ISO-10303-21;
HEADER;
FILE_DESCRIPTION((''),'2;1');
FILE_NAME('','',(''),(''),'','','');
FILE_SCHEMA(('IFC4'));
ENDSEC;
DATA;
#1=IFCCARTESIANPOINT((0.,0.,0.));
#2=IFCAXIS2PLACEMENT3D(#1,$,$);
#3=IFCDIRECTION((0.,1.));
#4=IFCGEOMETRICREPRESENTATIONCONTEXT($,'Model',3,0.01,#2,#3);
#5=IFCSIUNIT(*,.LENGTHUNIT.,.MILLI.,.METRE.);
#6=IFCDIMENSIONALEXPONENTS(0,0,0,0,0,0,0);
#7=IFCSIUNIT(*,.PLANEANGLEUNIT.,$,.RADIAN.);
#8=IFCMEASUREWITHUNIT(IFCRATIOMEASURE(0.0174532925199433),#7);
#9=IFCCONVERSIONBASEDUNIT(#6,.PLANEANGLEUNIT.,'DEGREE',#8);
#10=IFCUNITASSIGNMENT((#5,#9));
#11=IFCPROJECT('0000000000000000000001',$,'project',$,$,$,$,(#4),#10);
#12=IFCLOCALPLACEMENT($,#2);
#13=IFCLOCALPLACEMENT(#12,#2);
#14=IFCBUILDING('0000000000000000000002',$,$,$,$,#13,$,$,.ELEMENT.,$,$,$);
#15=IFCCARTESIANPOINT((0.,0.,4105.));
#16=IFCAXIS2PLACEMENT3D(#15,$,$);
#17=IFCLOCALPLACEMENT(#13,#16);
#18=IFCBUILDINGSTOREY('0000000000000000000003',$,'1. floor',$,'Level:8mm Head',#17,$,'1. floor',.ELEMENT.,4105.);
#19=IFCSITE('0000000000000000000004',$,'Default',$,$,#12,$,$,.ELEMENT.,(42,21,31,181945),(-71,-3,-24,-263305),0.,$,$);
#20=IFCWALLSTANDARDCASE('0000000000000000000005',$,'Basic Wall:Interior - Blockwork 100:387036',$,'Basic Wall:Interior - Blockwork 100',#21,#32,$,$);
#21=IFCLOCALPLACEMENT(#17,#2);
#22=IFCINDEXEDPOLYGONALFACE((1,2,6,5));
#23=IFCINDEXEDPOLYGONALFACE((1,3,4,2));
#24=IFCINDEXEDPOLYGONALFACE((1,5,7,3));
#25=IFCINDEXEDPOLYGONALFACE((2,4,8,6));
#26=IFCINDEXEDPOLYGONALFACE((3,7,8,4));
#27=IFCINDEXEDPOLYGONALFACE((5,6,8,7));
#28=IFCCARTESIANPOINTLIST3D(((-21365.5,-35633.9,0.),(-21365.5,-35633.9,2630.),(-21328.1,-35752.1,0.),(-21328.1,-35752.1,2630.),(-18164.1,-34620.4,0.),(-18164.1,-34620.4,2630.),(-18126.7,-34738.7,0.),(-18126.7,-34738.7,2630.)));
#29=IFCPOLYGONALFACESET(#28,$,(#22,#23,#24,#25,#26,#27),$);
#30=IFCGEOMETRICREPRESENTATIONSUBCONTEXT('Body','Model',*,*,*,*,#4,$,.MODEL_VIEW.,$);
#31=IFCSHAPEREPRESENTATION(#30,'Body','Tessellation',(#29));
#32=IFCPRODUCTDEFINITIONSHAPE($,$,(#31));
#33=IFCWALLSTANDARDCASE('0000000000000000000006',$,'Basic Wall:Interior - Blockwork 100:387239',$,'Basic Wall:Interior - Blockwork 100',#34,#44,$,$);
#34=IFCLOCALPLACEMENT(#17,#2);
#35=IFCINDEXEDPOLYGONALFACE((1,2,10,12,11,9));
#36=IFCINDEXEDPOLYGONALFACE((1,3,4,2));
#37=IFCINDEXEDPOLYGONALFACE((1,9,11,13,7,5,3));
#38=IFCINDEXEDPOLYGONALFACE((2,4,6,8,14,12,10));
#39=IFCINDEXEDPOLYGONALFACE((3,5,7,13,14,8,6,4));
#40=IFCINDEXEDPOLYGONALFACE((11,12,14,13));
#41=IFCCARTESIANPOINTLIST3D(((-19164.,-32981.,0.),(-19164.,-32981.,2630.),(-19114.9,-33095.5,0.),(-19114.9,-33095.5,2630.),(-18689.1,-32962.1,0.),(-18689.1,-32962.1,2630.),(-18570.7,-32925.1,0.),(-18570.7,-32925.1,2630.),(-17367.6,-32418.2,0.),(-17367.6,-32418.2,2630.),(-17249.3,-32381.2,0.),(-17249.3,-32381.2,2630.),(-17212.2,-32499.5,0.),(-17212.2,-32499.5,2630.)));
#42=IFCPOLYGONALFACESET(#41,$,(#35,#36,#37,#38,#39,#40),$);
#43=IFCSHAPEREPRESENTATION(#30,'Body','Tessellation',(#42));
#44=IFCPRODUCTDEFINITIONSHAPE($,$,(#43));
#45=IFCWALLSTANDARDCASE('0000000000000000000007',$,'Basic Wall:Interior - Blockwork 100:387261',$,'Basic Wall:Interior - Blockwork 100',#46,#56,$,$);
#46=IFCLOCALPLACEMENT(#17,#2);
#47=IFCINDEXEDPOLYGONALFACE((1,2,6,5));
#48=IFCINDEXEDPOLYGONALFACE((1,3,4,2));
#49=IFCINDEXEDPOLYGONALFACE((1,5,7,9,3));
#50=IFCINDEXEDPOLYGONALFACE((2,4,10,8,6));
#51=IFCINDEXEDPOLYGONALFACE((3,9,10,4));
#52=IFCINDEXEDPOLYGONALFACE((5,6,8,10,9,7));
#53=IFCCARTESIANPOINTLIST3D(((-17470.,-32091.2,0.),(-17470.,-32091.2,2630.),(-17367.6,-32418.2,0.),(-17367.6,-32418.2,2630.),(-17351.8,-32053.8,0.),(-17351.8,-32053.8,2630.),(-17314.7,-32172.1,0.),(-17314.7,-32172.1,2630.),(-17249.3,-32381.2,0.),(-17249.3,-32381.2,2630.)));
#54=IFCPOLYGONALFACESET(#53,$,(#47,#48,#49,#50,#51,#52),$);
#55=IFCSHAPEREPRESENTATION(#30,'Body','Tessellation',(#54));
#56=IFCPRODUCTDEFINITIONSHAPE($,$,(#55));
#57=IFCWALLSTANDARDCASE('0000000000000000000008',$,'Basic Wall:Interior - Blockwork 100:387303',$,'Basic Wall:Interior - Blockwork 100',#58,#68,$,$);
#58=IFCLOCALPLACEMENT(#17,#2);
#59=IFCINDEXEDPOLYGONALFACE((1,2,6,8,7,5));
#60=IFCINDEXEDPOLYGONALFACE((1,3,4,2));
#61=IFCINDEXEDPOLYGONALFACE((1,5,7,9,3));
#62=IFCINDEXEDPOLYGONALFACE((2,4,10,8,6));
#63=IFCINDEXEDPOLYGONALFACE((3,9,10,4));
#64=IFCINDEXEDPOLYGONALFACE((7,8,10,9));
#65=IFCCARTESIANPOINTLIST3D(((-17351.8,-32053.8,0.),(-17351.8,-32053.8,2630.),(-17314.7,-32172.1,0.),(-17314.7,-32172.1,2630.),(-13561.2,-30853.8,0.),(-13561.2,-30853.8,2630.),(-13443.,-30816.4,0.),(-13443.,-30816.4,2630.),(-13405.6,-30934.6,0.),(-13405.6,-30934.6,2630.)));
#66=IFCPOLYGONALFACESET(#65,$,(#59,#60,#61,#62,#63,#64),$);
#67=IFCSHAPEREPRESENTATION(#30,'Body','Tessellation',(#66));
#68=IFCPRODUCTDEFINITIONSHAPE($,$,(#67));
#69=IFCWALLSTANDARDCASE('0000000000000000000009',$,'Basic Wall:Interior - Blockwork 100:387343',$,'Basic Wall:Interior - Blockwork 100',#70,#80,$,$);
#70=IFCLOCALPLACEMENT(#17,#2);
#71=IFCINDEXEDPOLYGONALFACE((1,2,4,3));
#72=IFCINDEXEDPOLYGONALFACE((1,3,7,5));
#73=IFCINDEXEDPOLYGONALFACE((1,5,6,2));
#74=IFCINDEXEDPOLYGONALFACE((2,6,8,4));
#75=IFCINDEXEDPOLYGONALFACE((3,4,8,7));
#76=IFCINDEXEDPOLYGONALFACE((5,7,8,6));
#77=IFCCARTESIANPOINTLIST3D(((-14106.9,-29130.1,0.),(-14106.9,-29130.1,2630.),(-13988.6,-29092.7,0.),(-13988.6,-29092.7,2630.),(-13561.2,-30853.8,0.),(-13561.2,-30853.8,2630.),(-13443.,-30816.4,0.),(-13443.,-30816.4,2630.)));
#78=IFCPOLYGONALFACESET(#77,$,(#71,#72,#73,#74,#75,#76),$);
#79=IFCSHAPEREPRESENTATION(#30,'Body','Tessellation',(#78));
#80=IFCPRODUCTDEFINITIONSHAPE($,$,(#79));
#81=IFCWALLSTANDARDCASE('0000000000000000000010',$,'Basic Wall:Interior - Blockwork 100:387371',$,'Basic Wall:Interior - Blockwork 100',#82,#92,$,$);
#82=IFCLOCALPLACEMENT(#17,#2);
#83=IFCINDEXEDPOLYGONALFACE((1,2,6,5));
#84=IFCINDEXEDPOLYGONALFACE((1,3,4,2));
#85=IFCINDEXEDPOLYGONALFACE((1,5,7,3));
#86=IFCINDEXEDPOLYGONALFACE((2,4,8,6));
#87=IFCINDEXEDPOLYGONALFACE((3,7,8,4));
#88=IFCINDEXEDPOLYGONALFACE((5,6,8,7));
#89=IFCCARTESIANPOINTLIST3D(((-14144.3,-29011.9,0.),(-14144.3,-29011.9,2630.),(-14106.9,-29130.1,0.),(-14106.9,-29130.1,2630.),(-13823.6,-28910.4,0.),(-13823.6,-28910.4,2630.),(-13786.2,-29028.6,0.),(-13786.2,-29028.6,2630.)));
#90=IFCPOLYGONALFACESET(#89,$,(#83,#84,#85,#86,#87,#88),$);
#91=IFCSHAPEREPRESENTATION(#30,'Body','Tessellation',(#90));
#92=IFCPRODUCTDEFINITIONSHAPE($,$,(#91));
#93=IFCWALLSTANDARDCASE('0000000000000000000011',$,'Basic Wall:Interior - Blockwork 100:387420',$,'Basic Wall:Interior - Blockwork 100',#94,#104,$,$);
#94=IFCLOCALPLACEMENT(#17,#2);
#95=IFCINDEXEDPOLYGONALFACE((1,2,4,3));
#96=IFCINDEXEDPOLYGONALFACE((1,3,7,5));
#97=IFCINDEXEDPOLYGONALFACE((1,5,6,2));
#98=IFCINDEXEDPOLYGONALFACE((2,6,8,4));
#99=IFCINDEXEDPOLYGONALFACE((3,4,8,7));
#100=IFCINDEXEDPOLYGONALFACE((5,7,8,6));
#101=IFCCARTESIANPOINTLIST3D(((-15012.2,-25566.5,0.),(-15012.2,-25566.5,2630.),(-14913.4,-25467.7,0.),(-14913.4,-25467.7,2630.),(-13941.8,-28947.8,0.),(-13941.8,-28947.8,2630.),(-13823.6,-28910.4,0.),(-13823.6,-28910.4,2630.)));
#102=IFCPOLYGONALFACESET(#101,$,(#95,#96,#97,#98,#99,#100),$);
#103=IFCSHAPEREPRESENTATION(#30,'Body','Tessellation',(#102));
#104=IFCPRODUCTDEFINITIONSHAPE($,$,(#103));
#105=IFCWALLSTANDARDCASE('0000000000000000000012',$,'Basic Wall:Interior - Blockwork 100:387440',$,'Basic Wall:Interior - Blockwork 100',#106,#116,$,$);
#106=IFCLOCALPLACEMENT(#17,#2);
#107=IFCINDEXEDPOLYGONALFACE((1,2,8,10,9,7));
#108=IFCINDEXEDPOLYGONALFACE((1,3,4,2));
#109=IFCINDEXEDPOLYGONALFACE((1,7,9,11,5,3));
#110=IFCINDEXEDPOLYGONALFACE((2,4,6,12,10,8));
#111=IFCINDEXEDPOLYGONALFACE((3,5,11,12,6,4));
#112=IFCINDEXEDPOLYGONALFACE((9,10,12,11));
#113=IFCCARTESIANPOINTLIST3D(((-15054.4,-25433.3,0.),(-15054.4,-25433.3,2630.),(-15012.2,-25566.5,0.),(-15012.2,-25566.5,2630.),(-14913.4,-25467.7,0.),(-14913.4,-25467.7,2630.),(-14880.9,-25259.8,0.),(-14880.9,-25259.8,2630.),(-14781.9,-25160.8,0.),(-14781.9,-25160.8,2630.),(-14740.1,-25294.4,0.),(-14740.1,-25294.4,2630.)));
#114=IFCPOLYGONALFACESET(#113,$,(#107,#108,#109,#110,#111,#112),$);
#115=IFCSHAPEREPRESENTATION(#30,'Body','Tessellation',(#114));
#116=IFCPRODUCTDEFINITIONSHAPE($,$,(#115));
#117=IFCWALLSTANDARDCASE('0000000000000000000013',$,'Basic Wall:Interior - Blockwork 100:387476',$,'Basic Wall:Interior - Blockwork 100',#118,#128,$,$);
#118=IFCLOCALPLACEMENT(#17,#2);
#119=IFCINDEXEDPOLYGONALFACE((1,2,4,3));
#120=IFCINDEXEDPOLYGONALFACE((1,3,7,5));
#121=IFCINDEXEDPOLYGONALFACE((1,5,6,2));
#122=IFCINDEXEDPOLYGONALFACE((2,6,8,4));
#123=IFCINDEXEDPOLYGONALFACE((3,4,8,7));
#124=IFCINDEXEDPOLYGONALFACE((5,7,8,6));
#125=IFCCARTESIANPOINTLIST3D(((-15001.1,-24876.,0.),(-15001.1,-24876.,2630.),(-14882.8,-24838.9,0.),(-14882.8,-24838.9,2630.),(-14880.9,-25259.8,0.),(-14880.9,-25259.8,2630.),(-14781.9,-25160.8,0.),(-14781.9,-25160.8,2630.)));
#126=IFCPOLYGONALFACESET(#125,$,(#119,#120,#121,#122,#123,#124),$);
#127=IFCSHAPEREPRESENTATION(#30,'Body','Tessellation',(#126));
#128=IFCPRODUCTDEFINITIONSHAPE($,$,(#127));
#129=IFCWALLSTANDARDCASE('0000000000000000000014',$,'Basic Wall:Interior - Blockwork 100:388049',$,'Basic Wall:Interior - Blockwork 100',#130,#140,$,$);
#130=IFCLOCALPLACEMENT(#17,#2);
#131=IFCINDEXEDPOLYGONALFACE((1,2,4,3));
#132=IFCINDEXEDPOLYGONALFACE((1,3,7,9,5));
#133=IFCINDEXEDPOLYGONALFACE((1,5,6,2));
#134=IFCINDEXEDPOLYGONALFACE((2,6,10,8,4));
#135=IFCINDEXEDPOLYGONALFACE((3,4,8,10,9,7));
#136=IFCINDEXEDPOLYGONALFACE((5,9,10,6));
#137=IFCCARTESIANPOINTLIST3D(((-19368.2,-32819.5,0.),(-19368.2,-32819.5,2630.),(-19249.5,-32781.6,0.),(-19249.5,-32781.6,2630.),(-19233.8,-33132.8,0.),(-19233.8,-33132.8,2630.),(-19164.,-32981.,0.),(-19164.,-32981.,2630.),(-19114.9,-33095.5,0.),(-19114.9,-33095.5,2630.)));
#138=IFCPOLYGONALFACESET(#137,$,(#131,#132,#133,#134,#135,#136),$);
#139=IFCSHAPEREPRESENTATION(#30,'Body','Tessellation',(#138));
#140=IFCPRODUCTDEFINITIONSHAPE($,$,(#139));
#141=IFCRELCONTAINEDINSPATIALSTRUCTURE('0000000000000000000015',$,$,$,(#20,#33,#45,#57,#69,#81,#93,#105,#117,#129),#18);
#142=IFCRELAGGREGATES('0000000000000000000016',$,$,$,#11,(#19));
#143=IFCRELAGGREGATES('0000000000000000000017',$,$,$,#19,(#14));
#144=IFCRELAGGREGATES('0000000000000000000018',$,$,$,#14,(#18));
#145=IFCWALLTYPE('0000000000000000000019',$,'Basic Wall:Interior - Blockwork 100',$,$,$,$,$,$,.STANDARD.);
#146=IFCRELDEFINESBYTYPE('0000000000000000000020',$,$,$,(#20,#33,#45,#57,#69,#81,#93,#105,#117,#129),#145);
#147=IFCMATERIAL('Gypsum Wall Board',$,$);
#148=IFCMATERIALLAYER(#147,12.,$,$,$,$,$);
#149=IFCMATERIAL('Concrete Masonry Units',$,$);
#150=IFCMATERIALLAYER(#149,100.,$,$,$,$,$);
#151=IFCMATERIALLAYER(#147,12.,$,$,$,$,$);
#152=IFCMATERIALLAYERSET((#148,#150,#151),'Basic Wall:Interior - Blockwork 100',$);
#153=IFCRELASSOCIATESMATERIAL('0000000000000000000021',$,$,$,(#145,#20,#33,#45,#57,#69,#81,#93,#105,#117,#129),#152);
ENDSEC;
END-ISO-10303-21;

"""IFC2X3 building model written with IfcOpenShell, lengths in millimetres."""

from ifc_helpers import new_model, entity, si_unit, converted_unit, direction, frame, frame_2d, origin, place, context, subcontext, project, spatial, polyline, rectangle, outline, extrude, material, layer, layer_set, layer_usage, type_object, element, save


model = new_model("IFC2X3")

# Units and contexts
model_context = context("Model", 3, precision=0.01, world=origin(), true_north=direction((0.0, 1.0)))
body_context = subcontext(model_context, "Body", "Model", "MODEL_VIEW")
ifc_project = project(units=[si_unit("LENGTHUNIT", "METRE", prefix="MILLI"), converted_unit("PLANEANGLEUNIT", "DEGREE", entity("IfcRatioMeasure", 0.0174532925199433), si_unit("PLANEANGLEUNIT", "RADIAN"), dimensions=[0, 0, 0, 0, 0, 0, 0])], contexts=[model_context])

# Site, building, storey
site_placement = place(None, origin())
site = spatial("IfcSite", under=ifc_project, at=site_placement, Name="Default", CompositionType="ELEMENT", RefLatitude=(42, 21, 31, 181945), RefLongitude=(-71, -3, -24, -263305), RefElevation=0.0)
building_placement = place(site_placement, origin())
building = spatial("IfcBuilding", under=site, at=building_placement, CompositionType="ELEMENT")
storey_placement = place(building_placement, frame((0.0, 0.0, 4105.0)))
storey = spatial("IfcBuildingStorey", under=building, at=storey_placement, Name="1. floor", ObjectType="Level:8mm Head", LongName="1. floor", CompositionType="ELEMENT", Elevation=4105.0)

# Shared definitions
ifc_material_1 = material(Name="Gypsum Wall Board")

# Walls
ifc_layer_1 = layer(ifc_material_1, 12.0)
ifc_material_2 = material(Name="Concrete Masonry Units")
ifc_layer_2 = layer(ifc_material_2, 100.0)
ifc_layer_3 = layer(ifc_material_1, 12.0)
ifc_layer_set_1 = layer_set([ifc_layer_1, ifc_layer_2, ifc_layer_3], Name="Basic Wall:Interior - Blockwork 100")
wall_type_1 = type_object("IfcWallType", Name="Basic Wall:Interior - Blockwork 100", PredefinedType="STANDARD", material=ifc_layer_set_1)
ifc_layer_usage_1 = layer_usage(ifc_layer_set_1, "AXIS2", "NEGATIVE", 62.0)
wall_1_placement = place(storey_placement, frame((-18145.4, -34679.6, 0.0), z_axis=(0.0, 0.0, 1.0), x_axis=(-0.953372, -0.301797, 0.0)))
element("IfcWallStandardCase", 1, at=wall_1_placement, inside=storey, type_object=wall_type_1, material=ifc_layer_usage_1, Name="Basic Wall:Interior - Blockwork 100:387036", ObjectType="Basic Wall:Interior - Blockwork 100", context=body_context, shape_type="SweptSolid", body=[
    extrude(rectangle(XDim=3358.0, YDim=124.0, at=frame_2d((1679.0, 0.0), x_axis=(-1.0, 0.0))), origin(), (0.0, 0.0, 1.0), 2630.0),
])
ifc_layer_usage_2 = layer_usage(ifc_layer_set_1, "AXIS2", "NEGATIVE", 62.0)
wall_2_placement = place(storey_placement, frame((-19145.5, -33040.1, 0.0), z_axis=(0.0, 0.0, 1.0), x_axis=(0.954277, 0.298924, 0.0)))
element("IfcWallStandardCase", 2, at=wall_2_placement, inside=storey, type_object=wall_type_1, material=ifc_layer_usage_2, Name="Basic Wall:Interior - Blockwork 100:387239", ObjectType="Basic Wall:Interior - Blockwork 100", context=body_context, shape_type="SweptSolid", body=[
    extrude(outline(polyline([(2006.5, -62.0), (2006.5, 62.0), (1882.5, 62.0), (0.0, 62.0), (12.6, -62.0), (458.9, -62.0), (582.9, -62.0), (2006.5, -62.0)])), origin(), (0.0, 0.0, 1.0), 2630.0),
])
ifc_layer_usage_3 = layer_usage(ifc_layer_set_1, "AXIS2", "NEGATIVE", 62.0)
wall_3_placement = place(storey_placement, frame((-17308.4, -32399.7, 0.0), z_axis=(0.0, 0.0, 1.0), x_axis=(-0.298924, 0.954277, 0.0)))
element("IfcWallStandardCase", 3, at=wall_3_placement, inside=storey, type_object=wall_type_1, material=ifc_layer_usage_3, Name="Basic Wall:Interior - Blockwork 100:387261", ObjectType="Basic Wall:Interior - Blockwork 100", context=body_context, shape_type="SweptSolid", body=[
    extrude(outline(polyline([(343.1, -62.0), (342.7, 62.0), (0.0, 62.0), (0.0, -62.0), (219.1, -62.0), (343.1, -62.0)])), origin(), (0.0, 0.0, 1.0), 2630.0),
])
ifc_layer_usage_4 = layer_usage(ifc_layer_set_1, "AXIS2", "NEGATIVE", 62.0)
wall_4_placement = place(storey_placement, frame((-17333.5, -32113.0, 0.0), z_axis=(0.0, 0.0, 1.0), x_axis=(0.953372, 0.301797, 0.0)))
element("IfcWallStandardCase", 4, at=wall_4_placement, inside=storey, type_object=wall_type_1, material=ifc_layer_usage_4, Name="Basic Wall:Interior - Blockwork 100:387303", ObjectType="Basic Wall:Interior - Blockwork 100", context=body_context, shape_type="SweptSolid", body=[
    extrude(outline(polyline([(4100.4, -62.0), (4100.4, 62.0), (3976.4, 62.0), (0.4, 62.0), (0.0, -62.0), (4100.4, -62.0)])), origin(), (0.0, 0.0, 1.0), 2630.0),
])
ifc_layer_usage_5 = layer_usage(ifc_layer_set_1, "AXIS2", "NEGATIVE", 62.0)
wall_5_placement = place(storey_placement, frame((-13502.1, -30835.1, 0.0), z_axis=(0.0, 0.0, 1.0), x_axis=(-0.301797, 0.953372, 0.0)))
element("IfcWallStandardCase", 5, at=wall_5_placement, inside=storey, type_object=wall_type_1, material=ifc_layer_usage_5, Name="Basic Wall:Interior - Blockwork 100:387343", ObjectType="Basic Wall:Interior - Blockwork 100", context=body_context, shape_type="SweptSolid", body=[
    extrude(rectangle(XDim=1808.0, YDim=124.0, at=frame_2d((904.0, 0.0), x_axis=(-1.0, 0.0))), origin(), (0.0, 0.0, 1.0), 2630.0),
])
ifc_layer_usage_6 = layer_usage(ifc_layer_set_1, "AXIS2", "NEGATIVE", 62.0)
wall_6_placement = place(storey_placement, frame((-14125.6, -29071.0, 0.0), z_axis=(0.0, 0.0, 1.0), x_axis=(0.953372, 0.301797, 0.0)))
element("IfcWallStandardCase", 6, at=wall_6_placement, inside=storey, type_object=wall_type_1, material=ifc_layer_usage_6, Name="Basic Wall:Interior - Blockwork 100:387371", ObjectType="Basic Wall:Interior - Blockwork 100", context=body_context, shape_type="SweptSolid", body=[
    extrude(rectangle(XDim=336.4, YDim=124.0, at=frame_2d((168.2, 0.0), x_axis=(-1.0, 0.0))), origin(), (0.0, 0.0, 1.0), 2630.0),
])
ifc_layer_usage_7 = layer_usage(ifc_layer_set_1, "AXIS2", "NEGATIVE", 62.0)
wall_7_placement = place(storey_placement, frame((-13882.7, -28929.1, 0.0), z_axis=(0.0, 0.0, 1.0), x_axis=(-0.301797, 0.953372, 0.0)))
element("IfcWallStandardCase", 7, at=wall_7_placement, inside=storey, type_object=wall_type_1, material=ifc_layer_usage_7, Name="Basic Wall:Interior - Blockwork 100:387420", ObjectType="Basic Wall:Interior - Blockwork 100", context=body_context, shape_type="SweptSolid", body=[
    extrude(outline(polyline([(3611.1, -62.0), (3546.7, 62.0), (0.0, 62.0), (0.0, -62.0), (3611.1, -62.0)])), origin(), (0.0, 0.0, 1.0), 2630.0),
])
ifc_layer_usage_8 = layer_usage(ifc_layer_set_1, "AXIS2", "NEGATIVE", 62.0)
wall_8_placement = place(storey_placement, frame((-15056.0, -25522.6, 0.0), z_axis=(0.0, 0.0, 1.0), x_axis=(0.707107, 0.707107, 0.0)))
element("IfcWallStandardCase", 8, at=wall_8_placement, inside=storey, type_object=wall_type_1, material=ifc_layer_usage_8, Name="Basic Wall:Interior - Blockwork 100:387440", ObjectType="Basic Wall:Interior - Blockwork 100", context=body_context, shape_type="SweptSolid", body=[
    extrude(outline(polyline([(384.8, -62.0), (449.6, 62.0), (309.7, 62.0), (64.4, 62.0), (0.0, -62.0), (139.7, -62.0), (384.8, -62.0)])), origin(), (0.0, 0.0, 1.0), 2630.0),
])
ifc_layer_usage_9 = layer_usage(ifc_layer_set_1, "AXIS2", "NEGATIVE", 62.0)
wall_9_placement = place(storey_placement, frame((-14821.7, -25241.2, 0.0), z_axis=(0.0, 0.0, 1.0), x_axis=(-0.298924, 0.954277, 0.0)))
element("IfcWallStandardCase", 9, at=wall_9_placement, inside=storey, type_object=wall_type_1, material=ifc_layer_usage_9, Name="Basic Wall:Interior - Blockwork 100:387476", ObjectType="Basic Wall:Interior - Blockwork 100", context=body_context, shape_type="SweptSolid", body=[
    extrude(outline(polyline([(402.2, -62.0), (402.2, 62.0), (0.0, 62.0), (64.8, -62.0), (402.2, -62.0)])), origin(), (0.0, 0.0, 1.0), 2630.0),
])
ifc_layer_usage_10 = layer_usage(ifc_layer_set_1, "AXIS2", "NEGATIVE", 62.0)
wall_10_placement = place(storey_placement, frame((-19311.3, -32795.0, 0.0), z_axis=(0.0, 0.0, 1.0), x_axis=(0.394208, -0.919021, 0.0)))
element("IfcWallStandardCase", 10, at=wall_10_placement, inside=storey, type_object=wall_type_1, material=ifc_layer_usage_10, Name="Basic Wall:Interior - Blockwork 100:388049", ObjectType="Basic Wall:Interior - Blockwork 100", context=body_context, shape_type="SweptSolid", body=[
    extrude(outline(polyline([(340.9, -62.0), (353.6, 62.0), (228.9, 62.0), (12.0, 62.0), (0.0, -62.0), (340.9, -62.0)])), origin(), (0.0, 0.0, 1.0), 2630.0),
])

save(model, "model.ifc")
